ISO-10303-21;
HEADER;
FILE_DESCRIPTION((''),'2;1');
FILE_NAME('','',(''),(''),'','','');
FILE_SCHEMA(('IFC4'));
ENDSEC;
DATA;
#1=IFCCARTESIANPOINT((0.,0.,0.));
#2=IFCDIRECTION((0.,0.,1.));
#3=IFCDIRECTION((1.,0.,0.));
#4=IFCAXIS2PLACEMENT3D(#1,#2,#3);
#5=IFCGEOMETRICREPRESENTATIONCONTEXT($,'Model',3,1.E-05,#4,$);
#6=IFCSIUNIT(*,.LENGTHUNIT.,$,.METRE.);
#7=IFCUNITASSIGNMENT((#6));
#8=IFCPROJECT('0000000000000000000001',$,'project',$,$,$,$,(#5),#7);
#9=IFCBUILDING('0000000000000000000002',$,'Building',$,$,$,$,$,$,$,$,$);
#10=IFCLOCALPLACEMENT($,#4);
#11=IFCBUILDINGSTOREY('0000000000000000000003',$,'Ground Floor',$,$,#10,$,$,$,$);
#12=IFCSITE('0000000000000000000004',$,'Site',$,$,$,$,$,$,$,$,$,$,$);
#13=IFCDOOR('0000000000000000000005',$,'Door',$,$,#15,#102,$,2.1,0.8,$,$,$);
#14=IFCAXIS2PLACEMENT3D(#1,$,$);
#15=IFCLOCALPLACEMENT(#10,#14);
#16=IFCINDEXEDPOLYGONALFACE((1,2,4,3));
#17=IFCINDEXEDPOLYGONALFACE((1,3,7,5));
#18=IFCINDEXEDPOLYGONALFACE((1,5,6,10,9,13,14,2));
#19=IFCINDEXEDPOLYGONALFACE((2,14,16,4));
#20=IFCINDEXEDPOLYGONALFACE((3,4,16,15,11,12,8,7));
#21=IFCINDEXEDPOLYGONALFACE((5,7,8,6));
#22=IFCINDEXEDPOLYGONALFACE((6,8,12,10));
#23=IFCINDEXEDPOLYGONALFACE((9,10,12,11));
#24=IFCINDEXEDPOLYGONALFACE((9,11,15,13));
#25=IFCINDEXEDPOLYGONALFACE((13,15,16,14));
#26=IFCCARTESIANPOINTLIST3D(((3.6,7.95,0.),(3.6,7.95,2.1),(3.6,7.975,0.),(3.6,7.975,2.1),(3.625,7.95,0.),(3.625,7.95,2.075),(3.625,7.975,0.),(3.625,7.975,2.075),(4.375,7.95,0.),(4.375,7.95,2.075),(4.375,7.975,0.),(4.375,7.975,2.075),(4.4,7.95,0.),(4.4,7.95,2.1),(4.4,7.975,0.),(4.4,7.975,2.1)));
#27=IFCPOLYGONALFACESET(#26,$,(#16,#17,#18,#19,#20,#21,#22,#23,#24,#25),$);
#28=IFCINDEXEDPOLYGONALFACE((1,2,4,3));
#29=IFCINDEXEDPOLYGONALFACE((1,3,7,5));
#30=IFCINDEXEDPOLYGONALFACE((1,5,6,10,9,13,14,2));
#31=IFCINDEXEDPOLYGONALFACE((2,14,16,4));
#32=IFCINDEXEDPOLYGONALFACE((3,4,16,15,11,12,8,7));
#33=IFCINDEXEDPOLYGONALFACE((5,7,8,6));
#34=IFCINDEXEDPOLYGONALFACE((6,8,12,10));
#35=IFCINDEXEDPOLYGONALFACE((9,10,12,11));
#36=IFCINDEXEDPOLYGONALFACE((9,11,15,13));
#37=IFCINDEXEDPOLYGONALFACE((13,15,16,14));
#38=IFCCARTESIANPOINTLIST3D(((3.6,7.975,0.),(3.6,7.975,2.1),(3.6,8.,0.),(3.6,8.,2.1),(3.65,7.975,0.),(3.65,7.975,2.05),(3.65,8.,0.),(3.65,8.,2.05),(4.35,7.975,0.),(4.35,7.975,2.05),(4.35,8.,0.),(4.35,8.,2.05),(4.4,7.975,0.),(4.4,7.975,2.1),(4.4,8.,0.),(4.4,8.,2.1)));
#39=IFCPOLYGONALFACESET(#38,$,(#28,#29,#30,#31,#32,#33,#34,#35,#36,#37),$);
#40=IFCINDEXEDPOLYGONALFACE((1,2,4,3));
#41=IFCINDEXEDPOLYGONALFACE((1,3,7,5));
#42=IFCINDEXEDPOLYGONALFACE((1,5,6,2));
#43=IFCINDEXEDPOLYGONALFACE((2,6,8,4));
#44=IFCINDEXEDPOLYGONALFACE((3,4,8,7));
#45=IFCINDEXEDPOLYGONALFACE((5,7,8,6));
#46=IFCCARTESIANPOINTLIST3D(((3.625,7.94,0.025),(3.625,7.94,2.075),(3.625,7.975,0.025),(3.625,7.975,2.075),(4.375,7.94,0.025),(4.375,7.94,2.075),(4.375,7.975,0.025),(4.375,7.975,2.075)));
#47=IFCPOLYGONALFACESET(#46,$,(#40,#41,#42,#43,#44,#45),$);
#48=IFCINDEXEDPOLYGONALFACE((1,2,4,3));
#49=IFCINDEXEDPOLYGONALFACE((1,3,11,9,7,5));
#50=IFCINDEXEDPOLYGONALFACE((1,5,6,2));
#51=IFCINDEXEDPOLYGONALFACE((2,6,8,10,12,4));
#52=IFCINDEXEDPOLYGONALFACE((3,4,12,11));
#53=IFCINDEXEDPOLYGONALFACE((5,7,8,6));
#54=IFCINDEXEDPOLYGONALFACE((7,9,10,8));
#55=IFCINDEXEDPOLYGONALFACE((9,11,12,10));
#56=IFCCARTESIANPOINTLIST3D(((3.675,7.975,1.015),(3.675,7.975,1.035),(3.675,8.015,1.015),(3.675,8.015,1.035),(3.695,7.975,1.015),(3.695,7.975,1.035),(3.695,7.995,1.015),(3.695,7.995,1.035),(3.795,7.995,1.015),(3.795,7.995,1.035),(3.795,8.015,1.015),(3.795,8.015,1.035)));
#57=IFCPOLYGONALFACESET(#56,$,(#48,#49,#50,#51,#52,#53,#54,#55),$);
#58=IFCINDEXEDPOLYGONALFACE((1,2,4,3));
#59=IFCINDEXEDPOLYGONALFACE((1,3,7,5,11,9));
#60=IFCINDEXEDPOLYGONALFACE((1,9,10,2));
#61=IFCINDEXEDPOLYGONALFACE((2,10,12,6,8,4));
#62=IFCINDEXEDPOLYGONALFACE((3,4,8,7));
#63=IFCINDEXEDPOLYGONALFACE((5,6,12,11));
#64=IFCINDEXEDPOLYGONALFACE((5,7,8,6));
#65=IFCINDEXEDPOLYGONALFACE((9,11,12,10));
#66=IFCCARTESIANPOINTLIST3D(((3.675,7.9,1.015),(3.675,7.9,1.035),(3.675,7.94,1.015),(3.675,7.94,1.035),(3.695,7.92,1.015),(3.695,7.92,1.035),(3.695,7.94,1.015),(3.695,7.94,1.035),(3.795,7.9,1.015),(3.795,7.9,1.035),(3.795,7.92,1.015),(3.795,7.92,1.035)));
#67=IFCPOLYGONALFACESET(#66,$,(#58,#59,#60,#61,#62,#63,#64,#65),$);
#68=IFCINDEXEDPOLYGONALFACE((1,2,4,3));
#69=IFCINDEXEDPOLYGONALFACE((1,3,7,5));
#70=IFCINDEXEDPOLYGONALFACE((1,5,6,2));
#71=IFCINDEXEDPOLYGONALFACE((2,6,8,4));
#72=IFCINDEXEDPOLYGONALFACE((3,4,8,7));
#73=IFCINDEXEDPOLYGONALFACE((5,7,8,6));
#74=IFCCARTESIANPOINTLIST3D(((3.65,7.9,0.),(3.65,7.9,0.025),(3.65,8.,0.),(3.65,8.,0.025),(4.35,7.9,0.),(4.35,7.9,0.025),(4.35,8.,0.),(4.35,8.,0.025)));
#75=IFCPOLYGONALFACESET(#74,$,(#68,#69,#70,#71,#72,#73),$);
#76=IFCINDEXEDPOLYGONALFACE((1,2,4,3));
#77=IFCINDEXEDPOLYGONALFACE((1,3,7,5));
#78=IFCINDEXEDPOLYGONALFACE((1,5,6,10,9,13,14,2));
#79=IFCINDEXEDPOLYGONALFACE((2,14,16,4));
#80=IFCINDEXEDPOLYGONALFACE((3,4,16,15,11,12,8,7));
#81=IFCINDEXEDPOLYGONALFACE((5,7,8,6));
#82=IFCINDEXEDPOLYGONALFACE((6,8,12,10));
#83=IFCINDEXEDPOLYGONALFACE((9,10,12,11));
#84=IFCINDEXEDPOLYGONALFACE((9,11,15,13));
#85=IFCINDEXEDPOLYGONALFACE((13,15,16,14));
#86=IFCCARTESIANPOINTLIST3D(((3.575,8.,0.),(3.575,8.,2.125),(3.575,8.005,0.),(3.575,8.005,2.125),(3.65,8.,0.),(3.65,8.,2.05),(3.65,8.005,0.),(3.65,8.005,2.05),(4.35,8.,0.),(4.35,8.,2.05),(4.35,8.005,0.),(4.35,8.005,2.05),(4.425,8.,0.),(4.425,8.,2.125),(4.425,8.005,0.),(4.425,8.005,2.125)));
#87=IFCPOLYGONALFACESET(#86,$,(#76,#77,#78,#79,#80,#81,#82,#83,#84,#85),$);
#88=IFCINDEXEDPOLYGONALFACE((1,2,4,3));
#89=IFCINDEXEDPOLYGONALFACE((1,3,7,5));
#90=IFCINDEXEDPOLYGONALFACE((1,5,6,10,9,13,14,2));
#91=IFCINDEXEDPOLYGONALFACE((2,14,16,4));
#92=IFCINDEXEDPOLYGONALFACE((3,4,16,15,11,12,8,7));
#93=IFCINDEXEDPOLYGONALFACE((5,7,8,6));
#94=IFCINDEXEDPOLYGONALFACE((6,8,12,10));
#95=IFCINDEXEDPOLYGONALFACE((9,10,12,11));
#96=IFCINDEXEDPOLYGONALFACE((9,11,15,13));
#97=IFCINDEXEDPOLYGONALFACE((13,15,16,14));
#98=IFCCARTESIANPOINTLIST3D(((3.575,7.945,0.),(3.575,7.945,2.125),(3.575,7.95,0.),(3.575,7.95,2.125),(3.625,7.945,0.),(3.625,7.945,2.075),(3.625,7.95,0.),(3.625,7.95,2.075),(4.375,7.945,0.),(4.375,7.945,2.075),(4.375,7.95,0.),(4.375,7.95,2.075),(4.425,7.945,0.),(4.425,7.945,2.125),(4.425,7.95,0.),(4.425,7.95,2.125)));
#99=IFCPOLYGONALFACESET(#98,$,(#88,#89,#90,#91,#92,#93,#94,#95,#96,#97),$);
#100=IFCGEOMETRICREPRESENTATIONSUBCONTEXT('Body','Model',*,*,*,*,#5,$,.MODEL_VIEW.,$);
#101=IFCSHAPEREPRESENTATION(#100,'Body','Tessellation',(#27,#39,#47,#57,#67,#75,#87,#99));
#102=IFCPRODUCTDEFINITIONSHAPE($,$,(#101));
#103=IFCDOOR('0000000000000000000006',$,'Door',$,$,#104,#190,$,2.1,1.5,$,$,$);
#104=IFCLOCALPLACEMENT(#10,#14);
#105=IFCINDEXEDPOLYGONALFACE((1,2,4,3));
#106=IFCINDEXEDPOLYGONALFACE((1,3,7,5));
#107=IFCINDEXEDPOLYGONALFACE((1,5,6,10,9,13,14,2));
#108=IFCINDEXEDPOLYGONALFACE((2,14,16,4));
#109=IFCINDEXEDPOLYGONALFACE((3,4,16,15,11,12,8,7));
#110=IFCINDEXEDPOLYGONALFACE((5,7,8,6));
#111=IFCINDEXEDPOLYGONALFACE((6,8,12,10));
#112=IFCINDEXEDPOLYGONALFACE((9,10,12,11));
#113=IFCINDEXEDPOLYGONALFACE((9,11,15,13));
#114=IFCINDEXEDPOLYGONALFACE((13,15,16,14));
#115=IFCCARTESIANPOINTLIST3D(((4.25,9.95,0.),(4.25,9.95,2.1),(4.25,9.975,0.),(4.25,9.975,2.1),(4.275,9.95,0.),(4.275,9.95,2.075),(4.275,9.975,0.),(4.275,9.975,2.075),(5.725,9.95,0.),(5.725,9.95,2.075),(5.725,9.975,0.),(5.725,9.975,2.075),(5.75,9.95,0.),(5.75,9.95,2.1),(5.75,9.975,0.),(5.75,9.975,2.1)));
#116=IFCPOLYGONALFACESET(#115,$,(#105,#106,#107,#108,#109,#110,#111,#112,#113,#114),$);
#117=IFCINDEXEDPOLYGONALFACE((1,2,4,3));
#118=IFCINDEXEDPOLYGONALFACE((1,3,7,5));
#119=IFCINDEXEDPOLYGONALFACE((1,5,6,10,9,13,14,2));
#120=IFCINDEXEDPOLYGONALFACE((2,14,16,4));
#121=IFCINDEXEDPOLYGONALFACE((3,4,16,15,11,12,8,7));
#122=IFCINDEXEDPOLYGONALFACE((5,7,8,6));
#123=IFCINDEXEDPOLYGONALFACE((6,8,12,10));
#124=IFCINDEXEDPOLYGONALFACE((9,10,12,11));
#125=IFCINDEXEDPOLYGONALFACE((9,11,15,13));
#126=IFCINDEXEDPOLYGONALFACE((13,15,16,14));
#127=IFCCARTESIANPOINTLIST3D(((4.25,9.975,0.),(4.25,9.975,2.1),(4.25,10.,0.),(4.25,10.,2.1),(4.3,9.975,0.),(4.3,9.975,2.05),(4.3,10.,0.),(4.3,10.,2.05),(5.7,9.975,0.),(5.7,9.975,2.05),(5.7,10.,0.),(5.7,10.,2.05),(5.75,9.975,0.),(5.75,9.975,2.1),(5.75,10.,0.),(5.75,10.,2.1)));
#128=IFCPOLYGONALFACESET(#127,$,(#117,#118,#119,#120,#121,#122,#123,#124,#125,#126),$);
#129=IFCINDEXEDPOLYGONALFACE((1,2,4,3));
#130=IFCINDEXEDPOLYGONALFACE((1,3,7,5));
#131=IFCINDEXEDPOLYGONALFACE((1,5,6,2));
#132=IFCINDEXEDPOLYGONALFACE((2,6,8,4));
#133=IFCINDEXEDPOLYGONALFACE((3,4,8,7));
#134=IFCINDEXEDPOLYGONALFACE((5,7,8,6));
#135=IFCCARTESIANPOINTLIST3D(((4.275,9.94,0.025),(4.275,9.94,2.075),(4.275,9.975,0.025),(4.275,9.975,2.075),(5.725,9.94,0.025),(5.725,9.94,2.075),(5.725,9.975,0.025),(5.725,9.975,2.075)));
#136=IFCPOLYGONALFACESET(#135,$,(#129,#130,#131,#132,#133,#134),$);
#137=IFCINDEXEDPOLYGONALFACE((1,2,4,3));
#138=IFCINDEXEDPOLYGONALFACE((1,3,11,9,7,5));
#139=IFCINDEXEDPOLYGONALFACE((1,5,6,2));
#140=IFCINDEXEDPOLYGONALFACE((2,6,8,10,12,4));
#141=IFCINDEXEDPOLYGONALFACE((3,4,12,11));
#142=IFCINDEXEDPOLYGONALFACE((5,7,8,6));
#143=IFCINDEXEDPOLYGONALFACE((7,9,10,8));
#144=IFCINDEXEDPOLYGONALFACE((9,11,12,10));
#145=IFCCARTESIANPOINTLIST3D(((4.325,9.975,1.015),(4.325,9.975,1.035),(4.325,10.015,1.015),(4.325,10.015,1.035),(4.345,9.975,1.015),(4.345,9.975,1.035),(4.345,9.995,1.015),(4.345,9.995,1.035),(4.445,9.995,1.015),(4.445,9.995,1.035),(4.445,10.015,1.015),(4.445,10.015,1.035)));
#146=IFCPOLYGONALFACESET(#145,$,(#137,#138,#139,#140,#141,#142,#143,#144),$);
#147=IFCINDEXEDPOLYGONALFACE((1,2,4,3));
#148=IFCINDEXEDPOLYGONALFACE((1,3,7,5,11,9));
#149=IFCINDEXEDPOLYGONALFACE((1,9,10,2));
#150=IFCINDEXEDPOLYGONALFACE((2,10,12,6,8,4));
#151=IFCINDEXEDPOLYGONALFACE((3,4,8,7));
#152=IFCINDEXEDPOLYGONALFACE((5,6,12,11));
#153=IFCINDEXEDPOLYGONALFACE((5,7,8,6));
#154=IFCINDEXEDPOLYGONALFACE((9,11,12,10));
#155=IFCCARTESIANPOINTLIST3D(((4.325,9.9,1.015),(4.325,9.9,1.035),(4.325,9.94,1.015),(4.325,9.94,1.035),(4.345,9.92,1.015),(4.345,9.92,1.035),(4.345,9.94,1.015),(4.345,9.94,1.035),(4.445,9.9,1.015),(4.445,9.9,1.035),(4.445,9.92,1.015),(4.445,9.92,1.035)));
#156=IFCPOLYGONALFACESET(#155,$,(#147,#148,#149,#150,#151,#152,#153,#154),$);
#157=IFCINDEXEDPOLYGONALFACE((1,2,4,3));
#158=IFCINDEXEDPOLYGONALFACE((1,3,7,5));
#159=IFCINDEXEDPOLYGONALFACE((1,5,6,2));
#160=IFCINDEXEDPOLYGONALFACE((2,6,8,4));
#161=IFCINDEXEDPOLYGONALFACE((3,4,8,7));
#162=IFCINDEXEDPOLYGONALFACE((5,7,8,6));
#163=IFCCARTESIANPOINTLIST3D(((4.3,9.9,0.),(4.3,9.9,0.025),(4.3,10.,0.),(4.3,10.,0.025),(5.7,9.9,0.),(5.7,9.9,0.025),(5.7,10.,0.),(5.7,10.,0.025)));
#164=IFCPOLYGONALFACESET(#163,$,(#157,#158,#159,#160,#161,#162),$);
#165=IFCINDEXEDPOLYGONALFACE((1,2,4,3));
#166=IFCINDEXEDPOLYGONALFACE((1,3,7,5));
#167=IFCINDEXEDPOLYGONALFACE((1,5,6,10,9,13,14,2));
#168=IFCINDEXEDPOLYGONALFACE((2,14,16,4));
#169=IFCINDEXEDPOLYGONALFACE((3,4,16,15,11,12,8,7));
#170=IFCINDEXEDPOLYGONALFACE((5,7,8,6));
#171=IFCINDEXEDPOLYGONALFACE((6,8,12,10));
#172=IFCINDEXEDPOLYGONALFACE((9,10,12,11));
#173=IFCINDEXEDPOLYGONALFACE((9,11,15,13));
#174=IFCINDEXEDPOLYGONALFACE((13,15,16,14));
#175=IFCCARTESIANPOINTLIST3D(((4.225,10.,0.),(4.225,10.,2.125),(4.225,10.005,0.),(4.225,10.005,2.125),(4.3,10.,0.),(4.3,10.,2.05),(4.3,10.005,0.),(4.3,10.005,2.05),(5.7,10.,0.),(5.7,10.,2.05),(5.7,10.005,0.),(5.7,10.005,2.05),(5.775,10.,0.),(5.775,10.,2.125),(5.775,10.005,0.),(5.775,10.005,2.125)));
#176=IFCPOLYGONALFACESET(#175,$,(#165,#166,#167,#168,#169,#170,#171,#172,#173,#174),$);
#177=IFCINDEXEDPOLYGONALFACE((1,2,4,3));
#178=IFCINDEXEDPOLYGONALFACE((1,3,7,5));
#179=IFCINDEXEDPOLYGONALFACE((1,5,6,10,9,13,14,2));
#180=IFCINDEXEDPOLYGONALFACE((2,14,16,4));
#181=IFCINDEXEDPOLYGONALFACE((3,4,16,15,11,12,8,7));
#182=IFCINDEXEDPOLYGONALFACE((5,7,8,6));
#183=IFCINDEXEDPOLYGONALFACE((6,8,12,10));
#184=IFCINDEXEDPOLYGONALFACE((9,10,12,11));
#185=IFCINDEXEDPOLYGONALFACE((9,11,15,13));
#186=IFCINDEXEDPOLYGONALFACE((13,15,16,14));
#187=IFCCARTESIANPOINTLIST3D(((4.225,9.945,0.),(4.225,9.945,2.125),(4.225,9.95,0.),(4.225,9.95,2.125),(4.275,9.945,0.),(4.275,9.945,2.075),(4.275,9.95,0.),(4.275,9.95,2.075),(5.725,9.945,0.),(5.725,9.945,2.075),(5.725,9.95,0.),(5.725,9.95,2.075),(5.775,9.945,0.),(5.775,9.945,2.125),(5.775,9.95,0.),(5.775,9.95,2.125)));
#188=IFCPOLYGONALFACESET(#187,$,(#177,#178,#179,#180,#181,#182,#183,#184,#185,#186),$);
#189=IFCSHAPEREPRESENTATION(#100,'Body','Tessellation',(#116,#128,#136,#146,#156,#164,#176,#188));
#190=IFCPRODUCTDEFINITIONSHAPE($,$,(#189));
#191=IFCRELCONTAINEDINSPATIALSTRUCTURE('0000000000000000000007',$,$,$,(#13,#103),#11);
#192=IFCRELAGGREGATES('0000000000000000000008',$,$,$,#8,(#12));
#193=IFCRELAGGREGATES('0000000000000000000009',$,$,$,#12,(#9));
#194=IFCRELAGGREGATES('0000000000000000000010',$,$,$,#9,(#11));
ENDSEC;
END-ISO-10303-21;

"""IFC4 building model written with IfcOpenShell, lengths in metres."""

from ifc_helpers import new_model, si_unit, frame, origin_with_axes, place, context, subcontext, project, spatial, line, indexed_curve, outline, extrude, element, save


model = new_model("IFC4")

# Units and contexts
model_context = context("Model", 3, precision=1e-05, world=origin_with_axes())
body_context = subcontext(model_context, "Body", "Model", "MODEL_VIEW")
ifc_project = project(units=[si_unit("LENGTHUNIT", "METRE")], contexts=[model_context])

# Site, building, storey
site = spatial("IfcSite", under=ifc_project, Name="Site")
building = spatial("IfcBuilding", under=site, Name="Building")
storey_placement = place(None, origin_with_axes())
storey = spatial("IfcBuildingStorey", under=building, at=storey_placement, Name="Ground Floor")

# Doors
door_1_placement = place(storey_placement, frame((4.4, 8.0, 0.0), z_axis=(0.0, 0.0, 1.0), x_axis=(-1.0, 0.0, 0.0)))
element("IfcDoor", 1, at=door_1_placement, inside=storey, Name="Door", OverallHeight=2.1, OverallWidth=0.8, context=body_context, shape_type="SweptSolid", body=[
    extrude(outline(indexed_curve([(0.0, 0.0), (0.0, 2.1), (0.8, 2.1), (0.8, 0.0), (0.775, 0.0), (0.775, 2.075), (0.025, 2.075), (0.025, 0.0)], segments=[line(1, 2, 3, 4, 5, 6, 7, 8, 1)])), frame((0.0, 0.025, 0.0), z_axis=(0.0, -1.0, 0.0), x_axis=(1.0, 0.0, 0.0)), (0.0, 0.0, -1.0), 0.025),
    extrude(outline(indexed_curve([(0.0, 0.0), (0.0, 2.1), (0.8, 2.1), (0.8, 0.0), (0.75, 0.0), (0.75, 2.05), (0.05, 2.05), (0.05, 0.0)], segments=[line(1, 2, 3, 4, 5, 6, 7, 8, 1)])), frame((0.0, 0.0, 0.0), z_axis=(0.0, -1.0, 0.0), x_axis=(1.0, 0.0, 0.0)), (0.0, 0.0, -1.0), 0.025),
    extrude(outline(indexed_curve([(0.0, 0.0), (0.75, 0.0), (0.75, 0.035), (0.0, 0.035)], segments=[line(1, 2, 3, 4, 1)])), frame((0.025, 0.025, 0.025), z_axis=(0.0, 0.0, 1.0), x_axis=(1.0, 0.0, 0.0)), (0.0, 0.0, 1.0), 2.05),
    extrude(outline(indexed_curve([(0.0, 0.0), (0.0, -0.04), (-0.12, -0.04), (-0.12, -0.02), (-0.02, -0.02), (-0.02, 0.0)], segments=[line(1, 2, 3, 4, 5, 6, 1)])), frame((0.725, 0.025, 1.015), z_axis=(0.0, 0.0, 1.0), x_axis=(1.0, 0.0, 0.0)), (0.0, 0.0, 1.0), 0.02),
    extrude(outline(indexed_curve([(0.0, 0.0), (0.0, 0.04), (-0.12, 0.04), (-0.12, 0.02), (-0.02, 0.02), (-0.02, 0.0)], segments=[line(1, 2, 3, 4, 5, 6, 1)])), frame((0.725, 0.06, 1.015), z_axis=(0.0, 0.0, 1.0), x_axis=(1.0, 0.0, 0.0)), (0.0, 0.0, 1.0), 0.02),
    extrude(outline(indexed_curve([(0.0, 0.0), (0.7, 0.0), (0.7, 0.1), (0.0, 0.1)], segments=[line(1, 2, 3, 4, 1)])), frame((0.05, 0.0, 0.0), z_axis=(0.0, 0.0, 1.0), x_axis=(1.0, 0.0, 0.0)), (0.0, 0.0, 1.0), 0.025),
    extrude(outline(indexed_curve([(0.0, 0.0), (0.0, 2.125), (0.85, 2.125), (0.85, 0.0), (0.775, 0.0), (0.775, 2.05), (0.075, 2.05), (0.075, 0.0)], segments=[line(1, 2, 3, 4, 5, 6, 7, 8, 1)])), frame((-0.025, -0.005, 0.0), z_axis=(0.0, -1.0, 0.0), x_axis=(1.0, 0.0, 0.0)), (0.0, 0.0, -1.0), 0.005),
    extrude(outline(indexed_curve([(0.0, 0.0), (0.0, 2.125), (0.85, 2.125), (0.85, 0.0), (0.8, 0.0), (0.8, 2.075), (0.05, 2.075), (0.05, 0.0)], segments=[line(1, 2, 3, 4, 5, 6, 7, 8, 1)])), frame((-0.025, 0.05, 0.0), z_axis=(0.0, -1.0, 0.0), x_axis=(1.0, 0.0, 0.0)), (0.0, 0.0, -1.0), 0.005),
])
door_2_placement = place(storey_placement, frame((5.75, 10.0, 0.0), z_axis=(0.0, 0.0, 1.0), x_axis=(-1.0, 0.0, 0.0)))
element("IfcDoor", 2, at=door_2_placement, inside=storey, Name="Door", OverallHeight=2.1, OverallWidth=1.5, context=body_context, shape_type="SweptSolid", body=[
    extrude(outline(indexed_curve([(0.0, 0.0), (0.0, 2.1), (1.5, 2.1), (1.5, 0.0), (1.475, 0.0), (1.475, 2.075), (0.025, 2.075), (0.025, 0.0)], segments=[line(1, 2, 3, 4, 5, 6, 7, 8, 1)])), frame((0.0, 0.025, 0.0), z_axis=(0.0, -1.0, 0.0), x_axis=(1.0, 0.0, 0.0)), (0.0, 0.0, -1.0), 0.025),
    extrude(outline(indexed_curve([(0.0, 0.0), (0.0, 2.1), (1.5, 2.1), (1.5, 0.0), (1.45, 0.0), (1.45, 2.05), (0.05, 2.05), (0.05, 0.0)], segments=[line(1, 2, 3, 4, 5, 6, 7, 8, 1)])), frame((0.0, 0.0, 0.0), z_axis=(0.0, -1.0, 0.0), x_axis=(1.0, 0.0, 0.0)), (0.0, 0.0, -1.0), 0.025),
    extrude(outline(indexed_curve([(0.0, 0.0), (1.45, 0.0), (1.45, 0.035), (0.0, 0.035)], segments=[line(1, 2, 3, 4, 1)])), frame((0.025, 0.025, 0.025), z_axis=(0.0, 0.0, 1.0), x_axis=(1.0, 0.0, 0.0)), (0.0, 0.0, 1.0), 2.05),
    extrude(outline(indexed_curve([(0.0, 0.0), (0.0, -0.04), (-0.12, -0.04), (-0.12, -0.02), (-0.02, -0.02), (-0.02, 0.0)], segments=[line(1, 2, 3, 4, 5, 6, 1)])), frame((1.425, 0.025, 1.015), z_axis=(0.0, 0.0, 1.0), x_axis=(1.0, 0.0, 0.0)), (0.0, 0.0, 1.0), 0.02),
    extrude(outline(indexed_curve([(0.0, 0.0), (0.0, 0.04), (-0.12, 0.04), (-0.12, 0.02), (-0.02, 0.02), (-0.02, 0.0)], segments=[line(1, 2, 3, 4, 5, 6, 1)])), frame((1.425, 0.06, 1.015), z_axis=(0.0, 0.0, 1.0), x_axis=(1.0, 0.0, 0.0)), (0.0, 0.0, 1.0), 0.02),
    extrude(outline(indexed_curve([(0.0, 0.0), (1.4, 0.0), (1.4, 0.1), (0.0, 0.1)], segments=[line(1, 2, 3, 4, 1)])), frame((0.05, 0.0, 0.0), z_axis=(0.0, 0.0, 1.0), x_axis=(1.0, 0.0, 0.0)), (0.0, 0.0, 1.0), 0.025),
    extrude(outline(indexed_curve([(0.0, 0.0), (0.0, 2.125), (1.55, 2.125), (1.55, 0.0), (1.475, 0.0), (1.475, 2.05), (0.075, 2.05), (0.075, 0.0)], segments=[line(1, 2, 3, 4, 5, 6, 7, 8, 1)])), frame((-0.025, -0.005, 0.0), z_axis=(0.0, -1.0, 0.0), x_axis=(1.0, 0.0, 0.0)), (0.0, 0.0, -1.0), 0.005),
    extrude(outline(indexed_curve([(0.0, 0.0), (0.0, 2.125), (1.55, 2.125), (1.55, 0.0), (1.5, 0.0), (1.5, 2.075), (0.05, 2.075), (0.05, 0.0)], segments=[line(1, 2, 3, 4, 5, 6, 7, 8, 1)])), frame((-0.025, 0.05, 0.0), z_axis=(0.0, -1.0, 0.0), x_axis=(1.0, 0.0, 0.0)), (0.0, 0.0, -1.0), 0.005),
])

save(model, "model.ifc")
